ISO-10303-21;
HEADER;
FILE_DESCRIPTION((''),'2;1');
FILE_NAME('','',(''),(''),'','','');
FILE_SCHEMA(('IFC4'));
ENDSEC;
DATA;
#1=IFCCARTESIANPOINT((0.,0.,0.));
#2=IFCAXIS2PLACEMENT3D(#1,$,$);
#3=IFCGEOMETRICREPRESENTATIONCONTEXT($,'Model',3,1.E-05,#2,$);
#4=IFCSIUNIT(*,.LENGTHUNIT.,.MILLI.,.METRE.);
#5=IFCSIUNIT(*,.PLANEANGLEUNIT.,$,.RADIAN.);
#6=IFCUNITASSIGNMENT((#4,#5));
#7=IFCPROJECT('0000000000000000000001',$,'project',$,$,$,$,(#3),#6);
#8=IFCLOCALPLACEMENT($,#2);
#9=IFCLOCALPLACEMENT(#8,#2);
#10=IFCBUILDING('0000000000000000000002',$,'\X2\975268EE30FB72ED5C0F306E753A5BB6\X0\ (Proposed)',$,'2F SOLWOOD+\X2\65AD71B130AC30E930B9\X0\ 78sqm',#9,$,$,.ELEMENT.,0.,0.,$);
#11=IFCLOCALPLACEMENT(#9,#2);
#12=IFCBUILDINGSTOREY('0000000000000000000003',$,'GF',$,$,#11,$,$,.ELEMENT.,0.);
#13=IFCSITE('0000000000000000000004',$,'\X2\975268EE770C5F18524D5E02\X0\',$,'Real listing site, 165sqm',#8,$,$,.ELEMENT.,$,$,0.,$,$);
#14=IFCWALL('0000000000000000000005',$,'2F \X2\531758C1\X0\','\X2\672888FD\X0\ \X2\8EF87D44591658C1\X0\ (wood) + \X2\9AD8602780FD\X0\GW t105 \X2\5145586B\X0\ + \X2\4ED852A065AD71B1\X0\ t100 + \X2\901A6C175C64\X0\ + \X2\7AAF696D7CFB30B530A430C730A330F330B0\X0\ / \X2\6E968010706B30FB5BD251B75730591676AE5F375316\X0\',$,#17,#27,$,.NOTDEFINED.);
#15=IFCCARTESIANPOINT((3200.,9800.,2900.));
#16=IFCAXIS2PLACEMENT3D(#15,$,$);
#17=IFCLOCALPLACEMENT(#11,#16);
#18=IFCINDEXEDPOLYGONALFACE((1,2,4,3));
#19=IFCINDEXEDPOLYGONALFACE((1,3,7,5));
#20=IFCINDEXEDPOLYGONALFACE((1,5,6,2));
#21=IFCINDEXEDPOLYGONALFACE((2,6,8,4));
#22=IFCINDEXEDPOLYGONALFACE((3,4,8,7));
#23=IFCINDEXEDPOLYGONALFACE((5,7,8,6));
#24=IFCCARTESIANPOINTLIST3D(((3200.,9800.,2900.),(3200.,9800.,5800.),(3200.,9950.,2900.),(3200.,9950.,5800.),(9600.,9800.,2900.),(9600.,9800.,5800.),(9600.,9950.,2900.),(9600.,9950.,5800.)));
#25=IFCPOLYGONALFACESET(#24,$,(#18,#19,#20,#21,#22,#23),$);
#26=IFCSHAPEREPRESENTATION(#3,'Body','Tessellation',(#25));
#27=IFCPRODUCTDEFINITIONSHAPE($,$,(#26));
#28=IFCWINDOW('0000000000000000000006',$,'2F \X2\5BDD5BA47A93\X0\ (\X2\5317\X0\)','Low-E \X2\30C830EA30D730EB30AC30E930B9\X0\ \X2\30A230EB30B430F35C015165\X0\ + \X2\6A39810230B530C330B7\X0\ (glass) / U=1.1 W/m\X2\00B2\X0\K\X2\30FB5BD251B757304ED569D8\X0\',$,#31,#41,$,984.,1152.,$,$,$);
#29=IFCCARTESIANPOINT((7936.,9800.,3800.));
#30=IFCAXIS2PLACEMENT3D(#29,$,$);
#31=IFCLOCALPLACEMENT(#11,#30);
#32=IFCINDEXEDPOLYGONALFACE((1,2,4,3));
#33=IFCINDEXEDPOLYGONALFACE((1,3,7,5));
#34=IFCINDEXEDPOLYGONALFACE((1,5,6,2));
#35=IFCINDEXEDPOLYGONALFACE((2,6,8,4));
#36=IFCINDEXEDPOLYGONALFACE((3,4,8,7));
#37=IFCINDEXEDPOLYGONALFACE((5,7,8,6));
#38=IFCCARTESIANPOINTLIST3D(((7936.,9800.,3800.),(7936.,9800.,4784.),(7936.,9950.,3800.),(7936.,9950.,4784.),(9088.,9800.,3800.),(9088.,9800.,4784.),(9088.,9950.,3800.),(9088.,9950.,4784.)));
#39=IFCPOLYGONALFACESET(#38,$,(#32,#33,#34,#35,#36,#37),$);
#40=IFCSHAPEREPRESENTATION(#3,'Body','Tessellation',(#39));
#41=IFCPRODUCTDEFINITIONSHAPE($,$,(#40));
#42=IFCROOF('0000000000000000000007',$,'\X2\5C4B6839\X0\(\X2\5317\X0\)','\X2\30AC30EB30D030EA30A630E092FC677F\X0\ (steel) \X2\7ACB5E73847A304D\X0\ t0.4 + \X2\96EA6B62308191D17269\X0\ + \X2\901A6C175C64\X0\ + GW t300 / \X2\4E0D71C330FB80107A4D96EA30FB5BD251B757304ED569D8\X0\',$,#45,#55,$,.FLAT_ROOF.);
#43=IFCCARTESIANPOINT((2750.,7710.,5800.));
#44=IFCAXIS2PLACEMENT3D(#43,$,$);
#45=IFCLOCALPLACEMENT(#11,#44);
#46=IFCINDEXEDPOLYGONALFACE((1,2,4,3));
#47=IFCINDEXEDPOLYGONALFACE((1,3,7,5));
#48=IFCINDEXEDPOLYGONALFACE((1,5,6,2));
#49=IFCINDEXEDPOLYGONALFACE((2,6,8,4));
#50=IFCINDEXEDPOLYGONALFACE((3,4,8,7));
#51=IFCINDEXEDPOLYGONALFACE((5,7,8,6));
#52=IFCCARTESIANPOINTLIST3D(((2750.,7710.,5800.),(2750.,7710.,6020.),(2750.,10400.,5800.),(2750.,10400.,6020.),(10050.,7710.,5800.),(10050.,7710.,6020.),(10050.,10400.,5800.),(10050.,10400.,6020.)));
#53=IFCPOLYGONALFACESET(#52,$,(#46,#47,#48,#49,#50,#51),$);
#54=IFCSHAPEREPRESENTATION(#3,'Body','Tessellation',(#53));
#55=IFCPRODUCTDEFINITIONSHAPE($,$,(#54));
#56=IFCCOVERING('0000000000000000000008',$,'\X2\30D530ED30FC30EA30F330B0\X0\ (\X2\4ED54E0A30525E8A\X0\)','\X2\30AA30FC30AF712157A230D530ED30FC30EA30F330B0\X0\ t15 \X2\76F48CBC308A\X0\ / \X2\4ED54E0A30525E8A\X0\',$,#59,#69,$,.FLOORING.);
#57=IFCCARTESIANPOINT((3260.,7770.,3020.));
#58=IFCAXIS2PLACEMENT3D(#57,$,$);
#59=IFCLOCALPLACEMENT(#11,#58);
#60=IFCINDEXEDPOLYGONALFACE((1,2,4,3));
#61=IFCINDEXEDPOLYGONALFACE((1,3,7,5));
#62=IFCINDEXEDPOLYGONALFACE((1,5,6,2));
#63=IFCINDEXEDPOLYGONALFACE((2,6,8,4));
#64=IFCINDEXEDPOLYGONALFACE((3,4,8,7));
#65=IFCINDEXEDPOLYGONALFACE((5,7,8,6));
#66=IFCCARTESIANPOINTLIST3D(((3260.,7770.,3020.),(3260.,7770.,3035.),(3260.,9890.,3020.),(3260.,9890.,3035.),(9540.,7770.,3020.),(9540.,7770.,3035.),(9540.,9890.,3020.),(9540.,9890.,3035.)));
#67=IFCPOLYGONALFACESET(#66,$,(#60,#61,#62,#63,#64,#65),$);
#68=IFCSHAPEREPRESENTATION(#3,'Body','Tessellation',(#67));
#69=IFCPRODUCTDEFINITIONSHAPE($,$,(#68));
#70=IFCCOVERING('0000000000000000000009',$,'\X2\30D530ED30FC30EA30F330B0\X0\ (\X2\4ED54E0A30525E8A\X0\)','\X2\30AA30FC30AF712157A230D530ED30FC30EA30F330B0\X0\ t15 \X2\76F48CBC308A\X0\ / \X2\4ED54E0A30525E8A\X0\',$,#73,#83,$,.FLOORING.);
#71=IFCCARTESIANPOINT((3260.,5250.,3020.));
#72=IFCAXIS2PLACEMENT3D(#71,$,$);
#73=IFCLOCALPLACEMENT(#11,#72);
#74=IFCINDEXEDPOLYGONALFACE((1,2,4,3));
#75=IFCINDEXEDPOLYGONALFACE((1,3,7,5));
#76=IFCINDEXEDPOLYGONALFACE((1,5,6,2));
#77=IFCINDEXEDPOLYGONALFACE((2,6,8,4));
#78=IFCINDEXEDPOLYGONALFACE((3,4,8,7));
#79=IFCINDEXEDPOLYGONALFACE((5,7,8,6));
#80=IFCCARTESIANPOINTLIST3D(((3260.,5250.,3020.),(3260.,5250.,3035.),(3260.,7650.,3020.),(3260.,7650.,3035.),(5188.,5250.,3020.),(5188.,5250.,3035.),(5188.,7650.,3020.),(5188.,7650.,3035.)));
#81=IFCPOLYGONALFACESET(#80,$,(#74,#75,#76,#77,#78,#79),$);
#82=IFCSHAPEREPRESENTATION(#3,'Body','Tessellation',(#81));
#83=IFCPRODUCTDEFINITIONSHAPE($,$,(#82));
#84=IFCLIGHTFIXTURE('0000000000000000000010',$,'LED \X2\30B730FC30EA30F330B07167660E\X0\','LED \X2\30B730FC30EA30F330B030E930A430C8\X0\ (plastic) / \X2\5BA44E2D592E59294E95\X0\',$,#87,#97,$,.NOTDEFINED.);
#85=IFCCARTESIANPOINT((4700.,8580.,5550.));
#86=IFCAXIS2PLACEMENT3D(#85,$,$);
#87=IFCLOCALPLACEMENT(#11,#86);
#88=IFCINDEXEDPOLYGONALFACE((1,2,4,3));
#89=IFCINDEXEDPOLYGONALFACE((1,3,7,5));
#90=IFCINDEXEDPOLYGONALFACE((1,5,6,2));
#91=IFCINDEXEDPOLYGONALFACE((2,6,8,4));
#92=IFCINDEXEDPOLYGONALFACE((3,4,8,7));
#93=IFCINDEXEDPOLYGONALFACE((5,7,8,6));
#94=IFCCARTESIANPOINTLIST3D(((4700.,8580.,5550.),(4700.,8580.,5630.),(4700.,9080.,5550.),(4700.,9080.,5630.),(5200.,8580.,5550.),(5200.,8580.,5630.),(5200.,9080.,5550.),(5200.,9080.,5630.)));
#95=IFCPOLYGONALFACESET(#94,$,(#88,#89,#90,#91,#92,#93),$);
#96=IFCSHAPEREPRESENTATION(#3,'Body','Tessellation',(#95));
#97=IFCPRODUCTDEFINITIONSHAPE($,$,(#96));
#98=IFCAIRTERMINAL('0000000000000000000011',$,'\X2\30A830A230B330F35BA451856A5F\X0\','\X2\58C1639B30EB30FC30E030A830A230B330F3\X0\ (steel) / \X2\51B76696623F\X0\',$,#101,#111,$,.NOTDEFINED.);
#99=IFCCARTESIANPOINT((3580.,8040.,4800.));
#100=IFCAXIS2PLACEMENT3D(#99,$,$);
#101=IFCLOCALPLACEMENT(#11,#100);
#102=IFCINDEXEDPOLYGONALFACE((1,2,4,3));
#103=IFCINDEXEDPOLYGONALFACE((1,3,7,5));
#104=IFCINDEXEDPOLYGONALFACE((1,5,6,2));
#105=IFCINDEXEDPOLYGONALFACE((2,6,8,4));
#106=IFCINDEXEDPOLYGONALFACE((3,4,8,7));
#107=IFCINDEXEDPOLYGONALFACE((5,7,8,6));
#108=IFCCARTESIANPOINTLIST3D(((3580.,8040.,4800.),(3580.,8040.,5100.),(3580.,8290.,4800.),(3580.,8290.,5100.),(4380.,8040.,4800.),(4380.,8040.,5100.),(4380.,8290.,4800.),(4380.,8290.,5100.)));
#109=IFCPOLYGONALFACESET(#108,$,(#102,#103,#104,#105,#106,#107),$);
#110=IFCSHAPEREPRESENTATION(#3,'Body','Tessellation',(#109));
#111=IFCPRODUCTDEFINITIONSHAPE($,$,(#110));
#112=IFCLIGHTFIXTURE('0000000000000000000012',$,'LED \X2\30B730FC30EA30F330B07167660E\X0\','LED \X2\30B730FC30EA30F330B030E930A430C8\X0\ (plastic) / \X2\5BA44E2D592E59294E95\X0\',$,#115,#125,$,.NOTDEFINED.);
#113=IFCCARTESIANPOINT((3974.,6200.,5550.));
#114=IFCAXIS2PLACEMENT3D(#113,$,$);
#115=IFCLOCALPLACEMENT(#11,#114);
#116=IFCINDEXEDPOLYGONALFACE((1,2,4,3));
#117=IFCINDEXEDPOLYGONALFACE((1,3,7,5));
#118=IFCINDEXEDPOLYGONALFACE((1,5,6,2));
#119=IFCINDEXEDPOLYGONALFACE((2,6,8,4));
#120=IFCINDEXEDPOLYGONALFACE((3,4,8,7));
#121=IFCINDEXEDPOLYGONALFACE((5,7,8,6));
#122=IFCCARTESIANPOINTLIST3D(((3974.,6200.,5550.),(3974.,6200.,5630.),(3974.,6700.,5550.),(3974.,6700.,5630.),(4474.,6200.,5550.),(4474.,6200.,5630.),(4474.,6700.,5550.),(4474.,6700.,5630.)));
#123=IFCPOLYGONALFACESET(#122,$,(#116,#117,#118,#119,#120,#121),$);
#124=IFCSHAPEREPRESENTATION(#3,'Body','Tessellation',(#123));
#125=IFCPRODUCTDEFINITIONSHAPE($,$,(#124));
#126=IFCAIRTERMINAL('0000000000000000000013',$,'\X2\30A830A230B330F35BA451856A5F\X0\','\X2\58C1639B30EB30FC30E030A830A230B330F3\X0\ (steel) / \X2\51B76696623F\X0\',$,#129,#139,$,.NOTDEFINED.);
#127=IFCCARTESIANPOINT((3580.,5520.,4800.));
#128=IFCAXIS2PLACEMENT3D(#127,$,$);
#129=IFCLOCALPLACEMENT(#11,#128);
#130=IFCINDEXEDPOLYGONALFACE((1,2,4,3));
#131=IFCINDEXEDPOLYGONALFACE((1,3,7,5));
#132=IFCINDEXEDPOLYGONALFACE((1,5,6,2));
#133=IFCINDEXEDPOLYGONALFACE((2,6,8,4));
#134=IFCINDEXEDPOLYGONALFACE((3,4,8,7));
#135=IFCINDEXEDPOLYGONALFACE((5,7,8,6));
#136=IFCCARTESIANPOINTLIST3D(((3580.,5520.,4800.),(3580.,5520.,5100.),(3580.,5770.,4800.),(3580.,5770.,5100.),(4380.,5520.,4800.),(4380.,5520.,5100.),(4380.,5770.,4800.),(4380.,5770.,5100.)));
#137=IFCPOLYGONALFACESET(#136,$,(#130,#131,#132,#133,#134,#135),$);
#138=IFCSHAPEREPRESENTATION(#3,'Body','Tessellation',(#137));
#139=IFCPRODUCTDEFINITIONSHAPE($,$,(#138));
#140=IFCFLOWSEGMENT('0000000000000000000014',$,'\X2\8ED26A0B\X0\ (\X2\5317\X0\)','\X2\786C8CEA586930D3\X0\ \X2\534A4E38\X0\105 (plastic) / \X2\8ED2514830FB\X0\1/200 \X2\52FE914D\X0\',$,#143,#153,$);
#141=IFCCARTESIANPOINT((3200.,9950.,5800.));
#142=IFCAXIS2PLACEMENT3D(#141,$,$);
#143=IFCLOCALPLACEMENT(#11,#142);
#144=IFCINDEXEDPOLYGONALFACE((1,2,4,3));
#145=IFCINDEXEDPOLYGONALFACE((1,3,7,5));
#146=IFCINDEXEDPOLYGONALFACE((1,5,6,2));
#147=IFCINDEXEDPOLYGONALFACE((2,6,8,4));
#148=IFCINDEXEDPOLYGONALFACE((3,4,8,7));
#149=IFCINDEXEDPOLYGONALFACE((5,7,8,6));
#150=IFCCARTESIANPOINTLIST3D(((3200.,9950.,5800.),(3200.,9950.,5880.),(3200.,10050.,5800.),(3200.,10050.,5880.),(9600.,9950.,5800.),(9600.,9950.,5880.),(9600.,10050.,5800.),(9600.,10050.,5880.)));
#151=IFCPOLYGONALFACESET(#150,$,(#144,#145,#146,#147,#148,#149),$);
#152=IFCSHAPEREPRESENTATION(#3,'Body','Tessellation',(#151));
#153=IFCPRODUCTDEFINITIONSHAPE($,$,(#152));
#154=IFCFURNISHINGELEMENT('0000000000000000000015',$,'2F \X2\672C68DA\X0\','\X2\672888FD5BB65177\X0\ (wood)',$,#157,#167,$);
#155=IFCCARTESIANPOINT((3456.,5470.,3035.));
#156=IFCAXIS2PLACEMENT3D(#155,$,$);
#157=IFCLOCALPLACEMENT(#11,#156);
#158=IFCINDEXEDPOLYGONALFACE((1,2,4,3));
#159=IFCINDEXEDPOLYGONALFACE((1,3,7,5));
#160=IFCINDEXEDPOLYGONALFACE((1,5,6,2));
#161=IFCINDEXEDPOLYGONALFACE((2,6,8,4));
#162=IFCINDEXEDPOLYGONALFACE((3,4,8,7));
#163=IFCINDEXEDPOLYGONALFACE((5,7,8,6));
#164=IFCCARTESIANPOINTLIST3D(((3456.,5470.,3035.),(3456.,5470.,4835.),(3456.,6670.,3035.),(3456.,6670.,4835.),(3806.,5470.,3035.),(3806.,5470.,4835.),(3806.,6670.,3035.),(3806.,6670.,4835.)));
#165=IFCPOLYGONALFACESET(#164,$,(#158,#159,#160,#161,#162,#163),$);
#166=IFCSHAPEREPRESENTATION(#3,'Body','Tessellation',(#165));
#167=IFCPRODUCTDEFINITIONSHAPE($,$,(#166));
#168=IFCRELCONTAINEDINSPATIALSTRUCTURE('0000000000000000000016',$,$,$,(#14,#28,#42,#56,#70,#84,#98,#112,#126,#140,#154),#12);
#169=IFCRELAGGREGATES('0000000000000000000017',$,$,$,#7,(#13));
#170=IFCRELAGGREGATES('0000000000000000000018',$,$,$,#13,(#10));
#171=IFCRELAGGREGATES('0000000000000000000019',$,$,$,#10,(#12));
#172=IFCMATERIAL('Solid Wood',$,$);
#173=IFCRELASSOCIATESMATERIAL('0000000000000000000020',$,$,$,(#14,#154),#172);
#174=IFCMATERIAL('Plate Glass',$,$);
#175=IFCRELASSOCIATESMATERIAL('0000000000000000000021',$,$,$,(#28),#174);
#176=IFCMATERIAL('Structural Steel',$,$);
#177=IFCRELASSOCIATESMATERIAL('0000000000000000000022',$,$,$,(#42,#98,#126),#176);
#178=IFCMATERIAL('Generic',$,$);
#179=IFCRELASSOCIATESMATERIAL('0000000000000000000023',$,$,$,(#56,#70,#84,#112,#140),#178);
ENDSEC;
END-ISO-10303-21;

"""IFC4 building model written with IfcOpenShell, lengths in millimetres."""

from ifc_helpers import new_model, si_unit, frame, frame_2d, origin, place, context, project, spatial, rectangle, extrude, material, element, fill, save


model = new_model("IFC4")

# Units and contexts
model_context = context("Model", 3, precision=1e-05, world=origin())
ifc_project = project(units=[si_unit("LENGTHUNIT", "METRE", prefix="MILLI"), si_unit("PLANEANGLEUNIT", "RADIAN")], contexts=[model_context])

# Site, building, storey
site_placement = place(None, origin())
site = spatial("IfcSite", under=ifc_project, at=site_placement, Name="青森県弘前市", ObjectType="Real listing site, 165sqm", CompositionType="ELEMENT", RefElevation=0.0)
building_placement = place(site_placement, origin())
building = spatial("IfcBuilding", under=site, at=building_placement, Name="青森・狭小の町家 (Proposed)", ObjectType="2F SOLWOOD+断熱ガラス 78sqm", CompositionType="ELEMENT", ElevationOfRefHeight=0.0, ElevationOfTerrain=0.0)
storey_placement = place(building_placement, origin())
storey = spatial("IfcBuildingStorey", under=building, at=storey_placement, Name="GF", CompositionType="ELEMENT", Elevation=0.0)

# Shared definitions
ifc_material_1 = material(Name="Solid Wood")

# Wall, opening, window
wall_placement = place(storey_placement, frame((3200.0, 9800.0, 2900.0)))
wall = element("IfcWall", 1, at=wall_placement, inside=storey, material=ifc_material_1, Name="2F 北壁", Description="木製 軸組外壁 (wood) + 高性能GW t105 充填 + 付加断熱 t100 + 通気層 + 窯業系サイディング / 準耐火・寒冷地外皮強化", PredefinedType="NOTDEFINED", context=model_context, shape_type="SweptSolid", body=[
    extrude(rectangle(XDim=6400.0, YDim=150.0, at=frame_2d((3200.0, 75.0))), frame((3200.0, 9800.0, 2900.0)), (0.0, 0.0, 1.0), 2900.0),
])
opening_placement = place(storey_placement, frame((7936.0, 9800.0, 3800.0)))
opening = element("IfcOpeningElement", 2, at=opening_placement, cuts=wall, PredefinedType="NOTDEFINED", context=model_context, shape_type="SweptSolid", body=[
    extrude(rectangle(XDim=1152.0, YDim=150.0, at=frame_2d((576.0, 75.0))), frame((7936.0, 9800.0, 3800.0)), (0.0, 0.0, 1.0), 984.0),
])
ifc_material_2 = material(Name="Plate Glass")
window_placement = place(storey_placement, frame((7936.0, 9800.0, 3800.0)))
window = element("IfcWindow", 3, at=window_placement, inside=storey, material=ifc_material_2, Name="2F 寝室窓 (北)", Description="Low-E トリプルガラス アルゴン封入 + 樹脂サッシ (glass) / U=1.1 W/m²K・寒冷地仕様", OverallHeight=984.0, OverallWidth=1152.0, context=model_context, shape_type="SweptSolid", body=[
    extrude(rectangle(XDim=1152.0, YDim=150.0, at=frame_2d((576.0, 75.0))), frame((7936.0, 9800.0, 3800.0)), (0.0, 0.0, 1.0), 984.0),
])
fill(opening, window)

# Roof
ifc_material_3 = material(Name="Structural Steel")
for number, where, name in (
    (4, (2750.0, 7710.0, 5800.0), "屋根(北)"),
):
    element("IfcRoof", number, at=place(storey_placement, frame(where)), inside=storey, material=ifc_material_3, Name=name, Description="ガルバリウム鋼板 (steel) 立平葺き t0.4 + 雪止め金物 + 通気層 + GW t300 / 不燃・耐積雪・寒冷地仕様", PredefinedType="FLAT_ROOF", context=model_context, shape_type="SweptSolid", body=[
        extrude(rectangle(XDim=7300.0, YDim=2690.0, at=frame_2d((3650.0, 1345.0))), frame((2750.0, 7710.0, 5800.0)), (0.0, 0.0, 1.0), 220.0),
    ])

# Coverings
ifc_material_4 = material(Name="Generic")
covering_1_placement = place(storey_placement, frame((3260.0, 7770.0, 3020.0)))
element("IfcCovering", 5, at=covering_1_placement, inside=storey, material=ifc_material_4, Name="フローリング (仕上げ床)", Description="オーク無垢フローリング t15 直貼り / 仕上げ床", PredefinedType="FLOORING", context=model_context, shape_type="SweptSolid", body=[
    extrude(rectangle(XDim=6280.0, YDim=2120.0, at=frame_2d((3140.0, 1060.0))), frame((3260.0, 7770.0, 3020.0)), (0.0, 0.0, 1.0), 15.0),
])
covering_2_placement = place(storey_placement, frame((3260.0, 5250.0, 3020.0)))
element("IfcCovering", 6, at=covering_2_placement, inside=storey, material=ifc_material_4, Name="フローリング (仕上げ床)", Description="オーク無垢フローリング t15 直貼り / 仕上げ床", PredefinedType="FLOORING", context=model_context, shape_type="SweptSolid", body=[
    extrude(rectangle(XDim=1928.0, YDim=2400.0, at=frame_2d((964.0, 1200.0))), frame((3260.0, 5250.0, 3020.0)), (0.0, 0.0, 1.0), 15.0),
])

# Light fixture
light_fixture_1_placement = place(storey_placement, frame((4700.0, 8580.0, 5550.0)))
element("IfcLightFixture", 7, at=light_fixture_1_placement, inside=storey, material=ifc_material_4, Name="LED シーリング照明", Description="LED シーリングライト (plastic) / 室中央天井", PredefinedType="NOTDEFINED", context=model_context, shape_type="SweptSolid", body=[
    extrude(rectangle(XDim=500.0, YDim=500.0, at=frame_2d((250.0, 250.0))), frame((4700.0, 8580.0, 5550.0)), (0.0, 0.0, 1.0), 80.0),
])

# Air terminal
air_terminal_1_placement = place(storey_placement, frame((3580.0, 8040.0, 4800.0)))
element("IfcAirTerminal", 8, at=air_terminal_1_placement, inside=storey, material=ifc_material_3, Name="エアコン室内機", Description="壁掛ルームエアコン (steel) / 冷暖房", PredefinedType="NOTDEFINED", context=model_context, shape_type="SweptSolid", body=[
    extrude(rectangle(XDim=800.0, YDim=250.0, at=frame_2d((400.0, 125.0))), frame((3580.0, 8040.0, 4800.0)), (0.0, 0.0, 1.0), 300.0),
])

# Light fixture
light_fixture_2_placement = place(storey_placement, frame((3974.0, 6200.0, 5550.0)))
element("IfcLightFixture", 9, at=light_fixture_2_placement, inside=storey, material=ifc_material_4, Name="LED シーリング照明", Description="LED シーリングライト (plastic) / 室中央天井", PredefinedType="NOTDEFINED", context=model_context, shape_type="SweptSolid", body=[
    extrude(rectangle(XDim=500.0, YDim=500.0, at=frame_2d((250.0, 250.0))), frame((3974.0, 6200.0, 5550.0)), (0.0, 0.0, 1.0), 80.0),
])

# Air terminal
air_terminal_2_placement = place(storey_placement, frame((3580.0, 5520.0, 4800.0)))
element("IfcAirTerminal", 10, at=air_terminal_2_placement, inside=storey, material=ifc_material_3, Name="エアコン室内機", Description="壁掛ルームエアコン (steel) / 冷暖房", PredefinedType="NOTDEFINED", context=model_context, shape_type="SweptSolid", body=[
    extrude(rectangle(XDim=800.0, YDim=250.0, at=frame_2d((400.0, 125.0))), frame((3580.0, 5520.0, 4800.0)), (0.0, 0.0, 1.0), 300.0),
])

# Flow segment
flow_segment_placement = place(storey_placement, frame((3200.0, 9950.0, 5800.0)))
element("IfcFlowSegment", 11, at=flow_segment_placement, inside=storey, material=ifc_material_4, Name="軒樋 (北)", Description="硬質塩ビ 半丸105 (plastic) / 軒先・1/200 勾配", context=model_context, shape_type="SweptSolid", body=[
    extrude(rectangle(XDim=6400.0, YDim=100.0, at=frame_2d((3200.0, 50.0))), frame((3200.0, 9950.0, 5800.0)), (0.0, 0.0, 1.0), 80.0),
])

# Furnishing element
furnishing_placement = place(storey_placement, frame((3456.0, 5470.0, 3035.0)))
element("IfcFurnishingElement", 12, at=furnishing_placement, inside=storey, material=ifc_material_1, Name="2F 本棚", Description="木製家具 (wood)", context=model_context, shape_type="SweptSolid", body=[
    extrude(rectangle(XDim=350.0, YDim=1200.0, at=frame_2d((175.0, 600.0))), frame((3456.0, 5470.0, 3035.0)), (0.0, 0.0, 1.0), 1800.0),
])

save(model, "model.ifc")
